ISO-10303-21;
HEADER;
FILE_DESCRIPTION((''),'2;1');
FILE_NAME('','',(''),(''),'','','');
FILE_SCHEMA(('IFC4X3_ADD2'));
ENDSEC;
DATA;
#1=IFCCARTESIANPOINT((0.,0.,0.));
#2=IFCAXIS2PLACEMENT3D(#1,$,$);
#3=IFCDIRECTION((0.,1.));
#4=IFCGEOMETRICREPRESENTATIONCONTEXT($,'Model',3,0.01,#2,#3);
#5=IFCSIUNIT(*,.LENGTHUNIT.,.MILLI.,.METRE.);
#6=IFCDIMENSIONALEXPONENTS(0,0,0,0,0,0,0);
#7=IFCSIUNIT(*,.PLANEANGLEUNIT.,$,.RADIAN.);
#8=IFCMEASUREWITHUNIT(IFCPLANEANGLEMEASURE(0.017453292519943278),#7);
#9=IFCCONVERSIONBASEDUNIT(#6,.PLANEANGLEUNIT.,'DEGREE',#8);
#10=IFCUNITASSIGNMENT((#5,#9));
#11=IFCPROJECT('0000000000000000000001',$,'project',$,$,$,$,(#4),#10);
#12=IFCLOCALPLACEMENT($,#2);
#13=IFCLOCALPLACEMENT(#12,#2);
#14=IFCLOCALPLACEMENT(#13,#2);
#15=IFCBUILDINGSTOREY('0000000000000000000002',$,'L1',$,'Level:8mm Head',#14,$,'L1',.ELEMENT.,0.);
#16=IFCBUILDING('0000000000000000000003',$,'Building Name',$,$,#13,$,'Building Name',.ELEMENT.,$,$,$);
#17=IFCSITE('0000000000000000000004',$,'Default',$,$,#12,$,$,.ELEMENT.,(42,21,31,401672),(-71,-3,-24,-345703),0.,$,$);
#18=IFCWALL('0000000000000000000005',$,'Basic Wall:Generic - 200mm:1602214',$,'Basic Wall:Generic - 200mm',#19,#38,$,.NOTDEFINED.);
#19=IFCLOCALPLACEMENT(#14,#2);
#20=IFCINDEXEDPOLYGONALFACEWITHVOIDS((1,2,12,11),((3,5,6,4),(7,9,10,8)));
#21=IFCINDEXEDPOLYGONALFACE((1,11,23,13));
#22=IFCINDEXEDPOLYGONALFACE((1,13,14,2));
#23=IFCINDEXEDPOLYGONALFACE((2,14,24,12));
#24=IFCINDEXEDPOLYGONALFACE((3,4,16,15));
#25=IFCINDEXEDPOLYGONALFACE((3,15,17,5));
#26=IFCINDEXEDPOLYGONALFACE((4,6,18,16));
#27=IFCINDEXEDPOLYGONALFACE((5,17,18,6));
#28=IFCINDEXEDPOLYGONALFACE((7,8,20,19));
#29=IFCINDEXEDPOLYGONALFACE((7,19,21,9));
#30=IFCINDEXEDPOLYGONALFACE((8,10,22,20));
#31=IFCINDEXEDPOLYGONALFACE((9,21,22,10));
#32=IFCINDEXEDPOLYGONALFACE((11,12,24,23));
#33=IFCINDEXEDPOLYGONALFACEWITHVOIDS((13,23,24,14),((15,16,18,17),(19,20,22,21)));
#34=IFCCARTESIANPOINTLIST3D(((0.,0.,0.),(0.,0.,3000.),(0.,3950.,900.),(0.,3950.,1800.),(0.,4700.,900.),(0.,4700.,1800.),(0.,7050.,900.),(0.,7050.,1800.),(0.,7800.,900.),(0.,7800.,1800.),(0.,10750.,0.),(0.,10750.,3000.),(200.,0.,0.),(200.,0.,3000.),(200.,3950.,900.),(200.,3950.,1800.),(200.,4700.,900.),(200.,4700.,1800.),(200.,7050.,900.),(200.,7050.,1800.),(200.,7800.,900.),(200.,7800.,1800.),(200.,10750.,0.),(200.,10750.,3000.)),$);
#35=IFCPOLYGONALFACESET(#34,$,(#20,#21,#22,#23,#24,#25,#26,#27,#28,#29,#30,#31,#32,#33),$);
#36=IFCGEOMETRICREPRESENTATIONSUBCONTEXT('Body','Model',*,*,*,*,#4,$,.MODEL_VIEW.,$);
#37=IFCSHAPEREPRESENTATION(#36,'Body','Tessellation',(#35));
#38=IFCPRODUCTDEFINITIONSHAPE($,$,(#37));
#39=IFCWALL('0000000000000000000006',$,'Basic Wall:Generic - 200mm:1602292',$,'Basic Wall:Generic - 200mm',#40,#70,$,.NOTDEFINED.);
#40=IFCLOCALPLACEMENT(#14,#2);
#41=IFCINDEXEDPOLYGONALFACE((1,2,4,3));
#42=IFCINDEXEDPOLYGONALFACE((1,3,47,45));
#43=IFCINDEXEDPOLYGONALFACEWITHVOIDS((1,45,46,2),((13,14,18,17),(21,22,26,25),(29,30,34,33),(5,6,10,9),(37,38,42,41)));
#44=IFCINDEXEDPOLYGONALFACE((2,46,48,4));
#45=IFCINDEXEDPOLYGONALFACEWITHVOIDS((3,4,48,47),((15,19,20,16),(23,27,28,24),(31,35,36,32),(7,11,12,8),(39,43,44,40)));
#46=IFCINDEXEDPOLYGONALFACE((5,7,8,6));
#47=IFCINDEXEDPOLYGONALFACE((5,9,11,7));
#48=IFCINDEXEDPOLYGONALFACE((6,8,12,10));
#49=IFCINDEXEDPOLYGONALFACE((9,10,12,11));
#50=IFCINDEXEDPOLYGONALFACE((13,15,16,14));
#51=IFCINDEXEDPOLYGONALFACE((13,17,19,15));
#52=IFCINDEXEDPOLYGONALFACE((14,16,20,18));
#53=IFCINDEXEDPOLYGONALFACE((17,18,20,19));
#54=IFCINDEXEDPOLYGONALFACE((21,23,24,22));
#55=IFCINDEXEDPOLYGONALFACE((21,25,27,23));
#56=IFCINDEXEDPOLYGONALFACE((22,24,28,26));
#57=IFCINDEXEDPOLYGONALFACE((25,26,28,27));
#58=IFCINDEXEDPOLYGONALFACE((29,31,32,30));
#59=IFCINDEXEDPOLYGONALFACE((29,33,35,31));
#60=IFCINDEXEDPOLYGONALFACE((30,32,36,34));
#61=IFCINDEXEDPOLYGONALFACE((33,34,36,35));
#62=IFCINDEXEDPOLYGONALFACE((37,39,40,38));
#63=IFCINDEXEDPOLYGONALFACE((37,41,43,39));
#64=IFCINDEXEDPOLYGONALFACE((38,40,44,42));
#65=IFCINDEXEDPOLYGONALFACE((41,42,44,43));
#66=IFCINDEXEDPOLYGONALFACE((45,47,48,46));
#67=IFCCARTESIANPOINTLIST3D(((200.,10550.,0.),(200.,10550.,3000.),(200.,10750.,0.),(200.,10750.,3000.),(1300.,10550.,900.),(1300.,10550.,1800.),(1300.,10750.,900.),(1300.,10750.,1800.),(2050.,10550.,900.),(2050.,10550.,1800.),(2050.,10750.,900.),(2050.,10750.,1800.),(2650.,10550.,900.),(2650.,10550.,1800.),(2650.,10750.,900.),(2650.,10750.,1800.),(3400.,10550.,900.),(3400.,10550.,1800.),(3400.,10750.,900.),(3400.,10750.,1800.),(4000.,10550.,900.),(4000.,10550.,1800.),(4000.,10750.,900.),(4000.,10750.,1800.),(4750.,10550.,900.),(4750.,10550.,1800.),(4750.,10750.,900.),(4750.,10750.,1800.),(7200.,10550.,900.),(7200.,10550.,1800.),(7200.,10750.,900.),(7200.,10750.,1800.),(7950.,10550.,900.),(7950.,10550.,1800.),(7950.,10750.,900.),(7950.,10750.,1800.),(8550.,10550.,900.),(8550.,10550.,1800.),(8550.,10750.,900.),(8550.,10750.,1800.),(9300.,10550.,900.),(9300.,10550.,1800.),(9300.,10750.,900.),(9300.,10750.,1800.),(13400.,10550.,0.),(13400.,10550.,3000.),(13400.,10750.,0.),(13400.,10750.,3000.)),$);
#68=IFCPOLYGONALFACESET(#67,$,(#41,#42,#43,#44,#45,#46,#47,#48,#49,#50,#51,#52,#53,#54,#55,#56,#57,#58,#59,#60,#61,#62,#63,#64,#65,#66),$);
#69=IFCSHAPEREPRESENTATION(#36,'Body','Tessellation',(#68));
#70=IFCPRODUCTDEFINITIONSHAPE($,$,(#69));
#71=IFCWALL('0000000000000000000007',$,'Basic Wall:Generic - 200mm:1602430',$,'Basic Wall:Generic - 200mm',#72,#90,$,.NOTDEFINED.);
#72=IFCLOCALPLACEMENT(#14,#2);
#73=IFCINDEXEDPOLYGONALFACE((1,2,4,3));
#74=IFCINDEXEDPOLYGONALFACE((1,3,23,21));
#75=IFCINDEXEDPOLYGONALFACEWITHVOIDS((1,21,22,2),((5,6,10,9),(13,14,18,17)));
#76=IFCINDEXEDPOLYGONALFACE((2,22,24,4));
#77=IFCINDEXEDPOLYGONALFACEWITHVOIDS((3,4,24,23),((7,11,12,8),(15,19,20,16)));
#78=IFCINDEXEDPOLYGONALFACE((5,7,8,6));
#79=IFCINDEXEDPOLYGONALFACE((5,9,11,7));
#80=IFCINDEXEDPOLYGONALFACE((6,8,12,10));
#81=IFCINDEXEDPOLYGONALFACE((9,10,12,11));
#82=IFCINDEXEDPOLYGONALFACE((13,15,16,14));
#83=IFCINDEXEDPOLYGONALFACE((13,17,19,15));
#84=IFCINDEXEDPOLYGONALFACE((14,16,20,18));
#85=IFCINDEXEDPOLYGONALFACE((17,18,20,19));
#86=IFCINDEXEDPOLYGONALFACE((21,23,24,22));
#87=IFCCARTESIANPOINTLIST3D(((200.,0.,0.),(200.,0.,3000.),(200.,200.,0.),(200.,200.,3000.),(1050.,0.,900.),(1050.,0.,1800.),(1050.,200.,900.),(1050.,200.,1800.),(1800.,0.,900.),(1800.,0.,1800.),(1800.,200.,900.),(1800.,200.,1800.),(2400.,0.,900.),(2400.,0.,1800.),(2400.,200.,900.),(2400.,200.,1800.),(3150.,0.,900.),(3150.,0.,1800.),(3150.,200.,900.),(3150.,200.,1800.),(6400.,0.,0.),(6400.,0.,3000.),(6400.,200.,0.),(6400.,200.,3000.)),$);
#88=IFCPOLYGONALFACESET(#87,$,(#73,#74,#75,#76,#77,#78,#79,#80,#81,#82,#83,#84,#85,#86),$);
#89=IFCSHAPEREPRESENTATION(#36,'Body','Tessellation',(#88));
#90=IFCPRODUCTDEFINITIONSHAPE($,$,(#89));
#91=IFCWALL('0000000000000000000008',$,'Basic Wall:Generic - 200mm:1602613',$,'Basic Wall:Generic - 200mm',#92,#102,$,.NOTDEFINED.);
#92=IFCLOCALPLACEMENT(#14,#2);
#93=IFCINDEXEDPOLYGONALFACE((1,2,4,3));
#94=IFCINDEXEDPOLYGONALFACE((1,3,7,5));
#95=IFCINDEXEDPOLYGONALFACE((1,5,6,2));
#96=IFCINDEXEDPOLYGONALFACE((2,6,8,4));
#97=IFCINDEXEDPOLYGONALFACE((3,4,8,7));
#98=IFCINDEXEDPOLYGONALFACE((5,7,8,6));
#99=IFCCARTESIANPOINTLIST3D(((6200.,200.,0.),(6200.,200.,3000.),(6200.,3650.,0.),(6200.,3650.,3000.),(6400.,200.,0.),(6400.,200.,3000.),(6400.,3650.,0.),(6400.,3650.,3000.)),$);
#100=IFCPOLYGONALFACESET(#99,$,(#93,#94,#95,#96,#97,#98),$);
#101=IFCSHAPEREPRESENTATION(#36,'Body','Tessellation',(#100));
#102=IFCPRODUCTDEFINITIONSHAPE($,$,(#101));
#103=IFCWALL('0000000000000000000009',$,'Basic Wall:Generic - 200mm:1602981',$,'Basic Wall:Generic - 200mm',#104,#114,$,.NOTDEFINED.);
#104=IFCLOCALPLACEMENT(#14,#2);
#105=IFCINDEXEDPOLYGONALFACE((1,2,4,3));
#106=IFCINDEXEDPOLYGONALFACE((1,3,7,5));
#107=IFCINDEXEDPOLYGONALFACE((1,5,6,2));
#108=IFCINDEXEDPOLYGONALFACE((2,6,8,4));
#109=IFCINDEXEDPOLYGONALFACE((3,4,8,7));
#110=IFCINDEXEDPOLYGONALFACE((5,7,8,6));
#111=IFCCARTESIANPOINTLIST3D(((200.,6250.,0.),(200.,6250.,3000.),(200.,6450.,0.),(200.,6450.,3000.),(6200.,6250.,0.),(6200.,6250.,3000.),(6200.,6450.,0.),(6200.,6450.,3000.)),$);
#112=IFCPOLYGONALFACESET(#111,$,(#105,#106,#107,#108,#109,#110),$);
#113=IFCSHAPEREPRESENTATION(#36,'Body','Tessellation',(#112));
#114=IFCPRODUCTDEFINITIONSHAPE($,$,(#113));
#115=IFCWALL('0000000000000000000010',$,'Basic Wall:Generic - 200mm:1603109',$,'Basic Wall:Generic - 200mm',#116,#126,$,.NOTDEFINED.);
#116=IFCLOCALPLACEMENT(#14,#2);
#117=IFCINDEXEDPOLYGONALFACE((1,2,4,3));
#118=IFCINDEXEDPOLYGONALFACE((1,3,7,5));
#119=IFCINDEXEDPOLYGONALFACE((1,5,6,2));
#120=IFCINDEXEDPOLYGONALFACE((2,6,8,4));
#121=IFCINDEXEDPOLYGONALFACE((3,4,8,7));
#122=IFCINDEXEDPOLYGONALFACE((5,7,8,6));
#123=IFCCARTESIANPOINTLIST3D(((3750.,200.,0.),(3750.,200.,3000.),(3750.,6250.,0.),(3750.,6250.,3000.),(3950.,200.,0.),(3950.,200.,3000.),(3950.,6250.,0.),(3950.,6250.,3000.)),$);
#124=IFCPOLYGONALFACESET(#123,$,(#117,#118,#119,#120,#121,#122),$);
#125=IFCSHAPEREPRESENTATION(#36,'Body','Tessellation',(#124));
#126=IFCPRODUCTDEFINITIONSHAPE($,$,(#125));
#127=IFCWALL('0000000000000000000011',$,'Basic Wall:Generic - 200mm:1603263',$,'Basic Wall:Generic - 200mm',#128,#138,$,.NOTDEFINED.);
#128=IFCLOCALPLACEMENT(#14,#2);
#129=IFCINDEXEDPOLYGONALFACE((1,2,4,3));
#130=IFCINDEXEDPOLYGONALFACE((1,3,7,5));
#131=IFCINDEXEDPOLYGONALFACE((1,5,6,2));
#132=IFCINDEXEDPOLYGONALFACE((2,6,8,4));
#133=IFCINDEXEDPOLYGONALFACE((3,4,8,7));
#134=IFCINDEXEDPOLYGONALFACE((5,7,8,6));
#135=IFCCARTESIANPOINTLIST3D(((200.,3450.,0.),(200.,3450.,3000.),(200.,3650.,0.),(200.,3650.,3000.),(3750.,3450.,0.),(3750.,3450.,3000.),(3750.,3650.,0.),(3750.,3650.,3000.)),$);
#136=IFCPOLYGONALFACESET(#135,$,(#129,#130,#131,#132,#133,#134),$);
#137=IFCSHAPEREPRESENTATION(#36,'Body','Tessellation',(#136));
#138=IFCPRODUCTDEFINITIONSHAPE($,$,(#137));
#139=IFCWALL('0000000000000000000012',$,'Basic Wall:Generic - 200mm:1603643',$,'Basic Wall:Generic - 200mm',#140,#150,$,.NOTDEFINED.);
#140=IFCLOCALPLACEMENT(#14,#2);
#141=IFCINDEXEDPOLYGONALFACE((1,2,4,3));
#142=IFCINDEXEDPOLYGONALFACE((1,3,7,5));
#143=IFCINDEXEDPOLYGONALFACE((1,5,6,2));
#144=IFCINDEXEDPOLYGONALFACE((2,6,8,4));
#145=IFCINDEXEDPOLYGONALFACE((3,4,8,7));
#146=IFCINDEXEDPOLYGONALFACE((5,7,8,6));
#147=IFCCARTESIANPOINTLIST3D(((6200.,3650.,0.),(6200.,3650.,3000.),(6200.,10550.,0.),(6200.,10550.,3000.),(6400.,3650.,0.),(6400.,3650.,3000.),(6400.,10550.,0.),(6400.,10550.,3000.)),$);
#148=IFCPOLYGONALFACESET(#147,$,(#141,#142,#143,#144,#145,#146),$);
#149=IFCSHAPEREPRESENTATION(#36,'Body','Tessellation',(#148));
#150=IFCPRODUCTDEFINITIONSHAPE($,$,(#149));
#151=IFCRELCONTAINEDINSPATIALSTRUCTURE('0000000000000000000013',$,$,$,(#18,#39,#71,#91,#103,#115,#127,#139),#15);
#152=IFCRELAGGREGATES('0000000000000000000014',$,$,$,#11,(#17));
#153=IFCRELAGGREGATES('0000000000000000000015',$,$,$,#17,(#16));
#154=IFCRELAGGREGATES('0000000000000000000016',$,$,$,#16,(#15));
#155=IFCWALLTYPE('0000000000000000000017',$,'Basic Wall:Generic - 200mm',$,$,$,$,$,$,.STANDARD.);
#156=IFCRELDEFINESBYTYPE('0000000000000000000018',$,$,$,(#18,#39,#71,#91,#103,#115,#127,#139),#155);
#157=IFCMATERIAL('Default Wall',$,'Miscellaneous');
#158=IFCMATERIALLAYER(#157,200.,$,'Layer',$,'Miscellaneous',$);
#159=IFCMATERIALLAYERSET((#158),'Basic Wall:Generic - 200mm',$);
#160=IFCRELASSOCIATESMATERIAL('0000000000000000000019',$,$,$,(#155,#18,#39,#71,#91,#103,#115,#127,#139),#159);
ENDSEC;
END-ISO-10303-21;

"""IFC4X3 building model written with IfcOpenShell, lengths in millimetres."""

from ifc_helpers import new_model, entity, si_unit, converted_unit, direction, frame, frame_2d, origin, place, context, subcontext, project, spatial, rectangle, extrude, material, layer, layer_set, type_object, element, save


model = new_model("IFC4X3")

# Units and contexts
model_context = context("Model", 3, precision=0.01, world=origin(), true_north=direction((0.0, 1.0)))
body_context = subcontext(model_context, "Body", "Model", "MODEL_VIEW")
ifc_project = project(units=[si_unit("LENGTHUNIT", "METRE", prefix="MILLI"), converted_unit("PLANEANGLEUNIT", "DEGREE", entity("IfcPlaneAngleMeasure", 0.017453292519943278), si_unit("PLANEANGLEUNIT", "RADIAN"), dimensions=[0, 0, 0, 0, 0, 0, 0])], contexts=[model_context])

# Site, building, storey
site_placement = place(None, origin())
site = spatial("IfcSite", under=ifc_project, at=site_placement, Name="Default", CompositionType="ELEMENT", RefLatitude=(42, 21, 31, 401672), RefLongitude=(-71, -3, -24, -345703), RefElevation=0.0)
building_placement = place(site_placement, origin())
building = spatial("IfcBuilding", under=site, at=building_placement, Name="Building Name", LongName="Building Name", CompositionType="ELEMENT")
storey_placement = place(building_placement, origin())
storey = spatial("IfcBuildingStorey", under=building, at=storey_placement, Name="L1", ObjectType="Level:8mm Head", LongName="L1", CompositionType="ELEMENT", Elevation=0.0)

# Walls, openings
ifc_material_1 = material(Name="Default Wall", Category="Miscellaneous")
ifc_layer = layer(ifc_material_1, 200.0, Name="Layer", Category="Miscellaneous")
ifc_layer_set = layer_set([ifc_layer], Name="Basic Wall:Generic - 200mm")
wall_type = type_object("IfcWallType", Name="Basic Wall:Generic - 200mm", PredefinedType="STANDARD", material=ifc_layer_set)
wall_1_placement = place(storey_placement, frame((100.0, 0.0, 0.0), z_axis=(0.0, 0.0, 1.0), x_axis=(0.0, 1.0, 0.0)))
wall_1 = element("IfcWall", 1, at=wall_1_placement, inside=storey, type_object=wall_type, material=ifc_layer_set, Name="Basic Wall:Generic - 200mm:1602214", ObjectType="Basic Wall:Generic - 200mm", PredefinedType="NOTDEFINED", context=body_context, shape_type="SweptSolid", body=[
    extrude(rectangle(XDim=10750.0, YDim=200.0, at=frame_2d((5375.0, 0.0), x_axis=(-1.0, 0.0))), origin(), (0.0, 0.0, 1.0), 3000.0),
])
opening_1_placement = place(wall_1_placement, frame((3950.0, -100.0, 900.0)))
element("IfcOpeningElement", 2, at=opening_1_placement, cuts=wall_1, PredefinedType="OPENING", context=body_context, shape_type="SweptSolid", body=[
    extrude(rectangle(XDim=900.0, YDim=750.0, at=frame_2d((450.0, 375.0), x_axis=(-1.0, 0.0))), frame((0.0, 0.0, 0.0), z_axis=(0.0, 1.0, 0.0), x_axis=(0.0, 0.0, 1.0)), (0.0, 0.0, 1.0), 200.0),
])
opening_2_placement = place(wall_1_placement, frame((7050.0, -100.0, 900.0)))
element("IfcOpeningElement", 3, at=opening_2_placement, cuts=wall_1, PredefinedType="OPENING", context=body_context, shape_type="SweptSolid", body=[
    extrude(rectangle(XDim=900.0, YDim=750.0, at=frame_2d((450.0, 375.0), x_axis=(-1.0, 0.0))), frame((0.0, 0.0, 0.0), z_axis=(0.0, 1.0, 0.0), x_axis=(0.0, 0.0, 1.0)), (0.0, 0.0, 1.0), 200.0),
])
wall_2_placement = place(storey_placement, frame((200.0, 10650.0, 0.0)))
wall_2 = element("IfcWall", 4, at=wall_2_placement, inside=storey, type_object=wall_type, material=ifc_layer_set, Name="Basic Wall:Generic - 200mm:1602292", ObjectType="Basic Wall:Generic - 200mm", PredefinedType="NOTDEFINED", context=body_context, shape_type="SweptSolid", body=[
    extrude(rectangle(XDim=13200.0, YDim=200.0, at=frame_2d((6600.0, 0.0), x_axis=(-1.0, 0.0))), origin(), (0.0, 0.0, 1.0), 3000.0),
])
opening_3_placement = place(wall_2_placement, frame((1100.0, -100.0, 900.0)))
element("IfcOpeningElement", 5, at=opening_3_placement, cuts=wall_2, PredefinedType="OPENING", context=body_context, shape_type="SweptSolid", body=[
    extrude(rectangle(XDim=900.0, YDim=750.0, at=frame_2d((450.0, 375.0), x_axis=(-1.0, 0.0))), frame((0.0, 0.0, 0.0), z_axis=(0.0, 1.0, 0.0), x_axis=(0.0, 0.0, 1.0)), (0.0, 0.0, 1.0), 200.0),
])
opening_4_placement = place(wall_2_placement, frame((2450.0, -100.0, 900.0)))
element("IfcOpeningElement", 6, at=opening_4_placement, cuts=wall_2, PredefinedType="OPENING", context=body_context, shape_type="SweptSolid", body=[
    extrude(rectangle(XDim=900.0, YDim=750.0, at=frame_2d((450.0, 375.0), x_axis=(-1.0, 0.0))), frame((0.0, 0.0, 0.0), z_axis=(0.0, 1.0, 0.0), x_axis=(0.0, 0.0, 1.0)), (0.0, 0.0, 1.0), 200.0),
])
opening_5_placement = place(wall_2_placement, frame((3800.0, -100.0, 900.0)))
element("IfcOpeningElement", 7, at=opening_5_placement, cuts=wall_2, PredefinedType="OPENING", context=body_context, shape_type="SweptSolid", body=[
    extrude(rectangle(XDim=900.0, YDim=750.0, at=frame_2d((450.0, 375.0), x_axis=(-1.0, 0.0))), frame((0.0, 0.0, 0.0), z_axis=(0.0, 1.0, 0.0), x_axis=(0.0, 0.0, 1.0)), (0.0, 0.0, 1.0), 200.0),
])
opening_6_placement = place(wall_2_placement, frame((7000.0, -100.0, 900.0)))
element("IfcOpeningElement", 8, at=opening_6_placement, cuts=wall_2, PredefinedType="OPENING", context=body_context, shape_type="SweptSolid", body=[
    extrude(rectangle(XDim=900.0, YDim=750.0, at=frame_2d((450.0, 375.0), x_axis=(-1.0, 0.0))), frame((0.0, 0.0, 0.0), z_axis=(0.0, 1.0, 0.0), x_axis=(0.0, 0.0, 1.0)), (0.0, 0.0, 1.0), 200.0),
])
opening_7_placement = place(wall_2_placement, frame((8350.0, -100.0, 900.0)))
element("IfcOpeningElement", 9, at=opening_7_placement, cuts=wall_2, PredefinedType="OPENING", context=body_context, shape_type="SweptSolid", body=[
    extrude(rectangle(XDim=900.0, YDim=750.0, at=frame_2d((450.0, 375.0), x_axis=(-1.0, 0.0))), frame((0.0, 0.0, 0.0), z_axis=(0.0, 1.0, 0.0), x_axis=(0.0, 0.0, 1.0)), (0.0, 0.0, 1.0), 200.0),
])
wall_3_placement = place(storey_placement, frame((6400.0, 100.0, 0.0), z_axis=(0.0, 0.0, 1.0), x_axis=(-1.0, 0.0, 0.0)))
wall_3 = element("IfcWall", 10, at=wall_3_placement, inside=storey, type_object=wall_type, material=ifc_layer_set, Name="Basic Wall:Generic - 200mm:1602430", ObjectType="Basic Wall:Generic - 200mm", PredefinedType="NOTDEFINED", context=body_context, shape_type="SweptSolid", body=[
    extrude(rectangle(XDim=6200.0, YDim=200.0, at=frame_2d((3100.0, 0.0), x_axis=(-1.0, 0.0))), origin(), (0.0, 0.0, 1.0), 3000.0),
])
opening_8_placement = place(wall_3_placement, frame((3250.0, -100.0, 900.0)))
element("IfcOpeningElement", 11, at=opening_8_placement, cuts=wall_3, PredefinedType="OPENING", context=body_context, shape_type="SweptSolid", body=[
    extrude(rectangle(XDim=900.0, YDim=750.0, at=frame_2d((450.0, 375.0), x_axis=(-1.0, 0.0))), frame((0.0, 0.0, 0.0), z_axis=(0.0, 1.0, 0.0), x_axis=(0.0, 0.0, 1.0)), (0.0, 0.0, 1.0), 200.0),
])
opening_9_placement = place(wall_3_placement, frame((4600.0, -100.0, 900.0)))
element("IfcOpeningElement", 12, at=opening_9_placement, cuts=wall_3, PredefinedType="OPENING", context=body_context, shape_type="SweptSolid", body=[
    extrude(rectangle(XDim=900.0, YDim=750.0, at=frame_2d((450.0, 375.0), x_axis=(-1.0, 0.0))), frame((0.0, 0.0, 0.0), z_axis=(0.0, 1.0, 0.0), x_axis=(0.0, 0.0, 1.0)), (0.0, 0.0, 1.0), 200.0),
])

# Walls
wall_4_placement = place(storey_placement, frame((6300.0, 200.0, 0.0), z_axis=(0.0, 0.0, 1.0), x_axis=(0.0, 1.0, 0.0)))
element("IfcWall", 13, at=wall_4_placement, inside=storey, type_object=wall_type, material=ifc_layer_set, Name="Basic Wall:Generic - 200mm:1602613", ObjectType="Basic Wall:Generic - 200mm", PredefinedType="NOTDEFINED", context=body_context, shape_type="SweptSolid", body=[
    extrude(rectangle(XDim=3450.0, YDim=200.0, at=frame_2d((1725.0, 0.0), x_axis=(-1.0, 0.0))), origin(), (0.0, 0.0, 1.0), 3000.0),
])
wall_5_placement = place(storey_placement, frame((6200.0, 6350.0, 0.0), z_axis=(0.0, 0.0, 1.0), x_axis=(-1.0, 0.0, 0.0)))
element("IfcWall", 14, at=wall_5_placement, inside=storey, type_object=wall_type, material=ifc_layer_set, Name="Basic Wall:Generic - 200mm:1602981", ObjectType="Basic Wall:Generic - 200mm", PredefinedType="NOTDEFINED", context=body_context, shape_type="SweptSolid", body=[
    extrude(rectangle(XDim=6000.0, YDim=200.0, at=frame_2d((3000.0, 0.0), x_axis=(-1.0, 0.0))), origin(), (0.0, 0.0, 1.0), 3000.0),
])
wall_6_placement = place(storey_placement, frame((3850.0, 6250.0, 0.0), z_axis=(0.0, 0.0, 1.0), x_axis=(0.0, -1.0, 0.0)))
element("IfcWall", 15, at=wall_6_placement, inside=storey, type_object=wall_type, material=ifc_layer_set, Name="Basic Wall:Generic - 200mm:1603109", ObjectType="Basic Wall:Generic - 200mm", PredefinedType="NOTDEFINED", context=body_context, shape_type="SweptSolid", body=[
    extrude(rectangle(XDim=6050.0, YDim=200.0, at=frame_2d((3025.0, 0.0), x_axis=(-1.0, 0.0))), origin(), (0.0, 0.0, 1.0), 3000.0),
])
wall_7_placement = place(storey_placement, frame((3750.0, 3550.0, 0.0), z_axis=(0.0, 0.0, 1.0), x_axis=(-1.0, 0.0, 0.0)))
element("IfcWall", 16, at=wall_7_placement, inside=storey, type_object=wall_type, material=ifc_layer_set, Name="Basic Wall:Generic - 200mm:1603263", ObjectType="Basic Wall:Generic - 200mm", PredefinedType="NOTDEFINED", context=body_context, shape_type="SweptSolid", body=[
    extrude(rectangle(XDim=3550.0, YDim=200.0, at=frame_2d((1775.0, 0.0), x_axis=(-1.0, 0.0))), origin(), (0.0, 0.0, 1.0), 3000.0),
])
wall_8_placement = place(storey_placement, frame((6300.0, 3650.0, 0.0), z_axis=(0.0, 0.0, 1.0), x_axis=(0.0, 1.0, 0.0)))
element("IfcWall", 17, at=wall_8_placement, inside=storey, type_object=wall_type, material=ifc_layer_set, Name="Basic Wall:Generic - 200mm:1603643", ObjectType="Basic Wall:Generic - 200mm", PredefinedType="NOTDEFINED", context=body_context, shape_type="SweptSolid", body=[
    extrude(rectangle(XDim=6900.0, YDim=200.0, at=frame_2d((3450.0, 0.0), x_axis=(-1.0, 0.0))), origin(), (0.0, 0.0, 1.0), 3000.0),
])

save(model, "model.ifc")
